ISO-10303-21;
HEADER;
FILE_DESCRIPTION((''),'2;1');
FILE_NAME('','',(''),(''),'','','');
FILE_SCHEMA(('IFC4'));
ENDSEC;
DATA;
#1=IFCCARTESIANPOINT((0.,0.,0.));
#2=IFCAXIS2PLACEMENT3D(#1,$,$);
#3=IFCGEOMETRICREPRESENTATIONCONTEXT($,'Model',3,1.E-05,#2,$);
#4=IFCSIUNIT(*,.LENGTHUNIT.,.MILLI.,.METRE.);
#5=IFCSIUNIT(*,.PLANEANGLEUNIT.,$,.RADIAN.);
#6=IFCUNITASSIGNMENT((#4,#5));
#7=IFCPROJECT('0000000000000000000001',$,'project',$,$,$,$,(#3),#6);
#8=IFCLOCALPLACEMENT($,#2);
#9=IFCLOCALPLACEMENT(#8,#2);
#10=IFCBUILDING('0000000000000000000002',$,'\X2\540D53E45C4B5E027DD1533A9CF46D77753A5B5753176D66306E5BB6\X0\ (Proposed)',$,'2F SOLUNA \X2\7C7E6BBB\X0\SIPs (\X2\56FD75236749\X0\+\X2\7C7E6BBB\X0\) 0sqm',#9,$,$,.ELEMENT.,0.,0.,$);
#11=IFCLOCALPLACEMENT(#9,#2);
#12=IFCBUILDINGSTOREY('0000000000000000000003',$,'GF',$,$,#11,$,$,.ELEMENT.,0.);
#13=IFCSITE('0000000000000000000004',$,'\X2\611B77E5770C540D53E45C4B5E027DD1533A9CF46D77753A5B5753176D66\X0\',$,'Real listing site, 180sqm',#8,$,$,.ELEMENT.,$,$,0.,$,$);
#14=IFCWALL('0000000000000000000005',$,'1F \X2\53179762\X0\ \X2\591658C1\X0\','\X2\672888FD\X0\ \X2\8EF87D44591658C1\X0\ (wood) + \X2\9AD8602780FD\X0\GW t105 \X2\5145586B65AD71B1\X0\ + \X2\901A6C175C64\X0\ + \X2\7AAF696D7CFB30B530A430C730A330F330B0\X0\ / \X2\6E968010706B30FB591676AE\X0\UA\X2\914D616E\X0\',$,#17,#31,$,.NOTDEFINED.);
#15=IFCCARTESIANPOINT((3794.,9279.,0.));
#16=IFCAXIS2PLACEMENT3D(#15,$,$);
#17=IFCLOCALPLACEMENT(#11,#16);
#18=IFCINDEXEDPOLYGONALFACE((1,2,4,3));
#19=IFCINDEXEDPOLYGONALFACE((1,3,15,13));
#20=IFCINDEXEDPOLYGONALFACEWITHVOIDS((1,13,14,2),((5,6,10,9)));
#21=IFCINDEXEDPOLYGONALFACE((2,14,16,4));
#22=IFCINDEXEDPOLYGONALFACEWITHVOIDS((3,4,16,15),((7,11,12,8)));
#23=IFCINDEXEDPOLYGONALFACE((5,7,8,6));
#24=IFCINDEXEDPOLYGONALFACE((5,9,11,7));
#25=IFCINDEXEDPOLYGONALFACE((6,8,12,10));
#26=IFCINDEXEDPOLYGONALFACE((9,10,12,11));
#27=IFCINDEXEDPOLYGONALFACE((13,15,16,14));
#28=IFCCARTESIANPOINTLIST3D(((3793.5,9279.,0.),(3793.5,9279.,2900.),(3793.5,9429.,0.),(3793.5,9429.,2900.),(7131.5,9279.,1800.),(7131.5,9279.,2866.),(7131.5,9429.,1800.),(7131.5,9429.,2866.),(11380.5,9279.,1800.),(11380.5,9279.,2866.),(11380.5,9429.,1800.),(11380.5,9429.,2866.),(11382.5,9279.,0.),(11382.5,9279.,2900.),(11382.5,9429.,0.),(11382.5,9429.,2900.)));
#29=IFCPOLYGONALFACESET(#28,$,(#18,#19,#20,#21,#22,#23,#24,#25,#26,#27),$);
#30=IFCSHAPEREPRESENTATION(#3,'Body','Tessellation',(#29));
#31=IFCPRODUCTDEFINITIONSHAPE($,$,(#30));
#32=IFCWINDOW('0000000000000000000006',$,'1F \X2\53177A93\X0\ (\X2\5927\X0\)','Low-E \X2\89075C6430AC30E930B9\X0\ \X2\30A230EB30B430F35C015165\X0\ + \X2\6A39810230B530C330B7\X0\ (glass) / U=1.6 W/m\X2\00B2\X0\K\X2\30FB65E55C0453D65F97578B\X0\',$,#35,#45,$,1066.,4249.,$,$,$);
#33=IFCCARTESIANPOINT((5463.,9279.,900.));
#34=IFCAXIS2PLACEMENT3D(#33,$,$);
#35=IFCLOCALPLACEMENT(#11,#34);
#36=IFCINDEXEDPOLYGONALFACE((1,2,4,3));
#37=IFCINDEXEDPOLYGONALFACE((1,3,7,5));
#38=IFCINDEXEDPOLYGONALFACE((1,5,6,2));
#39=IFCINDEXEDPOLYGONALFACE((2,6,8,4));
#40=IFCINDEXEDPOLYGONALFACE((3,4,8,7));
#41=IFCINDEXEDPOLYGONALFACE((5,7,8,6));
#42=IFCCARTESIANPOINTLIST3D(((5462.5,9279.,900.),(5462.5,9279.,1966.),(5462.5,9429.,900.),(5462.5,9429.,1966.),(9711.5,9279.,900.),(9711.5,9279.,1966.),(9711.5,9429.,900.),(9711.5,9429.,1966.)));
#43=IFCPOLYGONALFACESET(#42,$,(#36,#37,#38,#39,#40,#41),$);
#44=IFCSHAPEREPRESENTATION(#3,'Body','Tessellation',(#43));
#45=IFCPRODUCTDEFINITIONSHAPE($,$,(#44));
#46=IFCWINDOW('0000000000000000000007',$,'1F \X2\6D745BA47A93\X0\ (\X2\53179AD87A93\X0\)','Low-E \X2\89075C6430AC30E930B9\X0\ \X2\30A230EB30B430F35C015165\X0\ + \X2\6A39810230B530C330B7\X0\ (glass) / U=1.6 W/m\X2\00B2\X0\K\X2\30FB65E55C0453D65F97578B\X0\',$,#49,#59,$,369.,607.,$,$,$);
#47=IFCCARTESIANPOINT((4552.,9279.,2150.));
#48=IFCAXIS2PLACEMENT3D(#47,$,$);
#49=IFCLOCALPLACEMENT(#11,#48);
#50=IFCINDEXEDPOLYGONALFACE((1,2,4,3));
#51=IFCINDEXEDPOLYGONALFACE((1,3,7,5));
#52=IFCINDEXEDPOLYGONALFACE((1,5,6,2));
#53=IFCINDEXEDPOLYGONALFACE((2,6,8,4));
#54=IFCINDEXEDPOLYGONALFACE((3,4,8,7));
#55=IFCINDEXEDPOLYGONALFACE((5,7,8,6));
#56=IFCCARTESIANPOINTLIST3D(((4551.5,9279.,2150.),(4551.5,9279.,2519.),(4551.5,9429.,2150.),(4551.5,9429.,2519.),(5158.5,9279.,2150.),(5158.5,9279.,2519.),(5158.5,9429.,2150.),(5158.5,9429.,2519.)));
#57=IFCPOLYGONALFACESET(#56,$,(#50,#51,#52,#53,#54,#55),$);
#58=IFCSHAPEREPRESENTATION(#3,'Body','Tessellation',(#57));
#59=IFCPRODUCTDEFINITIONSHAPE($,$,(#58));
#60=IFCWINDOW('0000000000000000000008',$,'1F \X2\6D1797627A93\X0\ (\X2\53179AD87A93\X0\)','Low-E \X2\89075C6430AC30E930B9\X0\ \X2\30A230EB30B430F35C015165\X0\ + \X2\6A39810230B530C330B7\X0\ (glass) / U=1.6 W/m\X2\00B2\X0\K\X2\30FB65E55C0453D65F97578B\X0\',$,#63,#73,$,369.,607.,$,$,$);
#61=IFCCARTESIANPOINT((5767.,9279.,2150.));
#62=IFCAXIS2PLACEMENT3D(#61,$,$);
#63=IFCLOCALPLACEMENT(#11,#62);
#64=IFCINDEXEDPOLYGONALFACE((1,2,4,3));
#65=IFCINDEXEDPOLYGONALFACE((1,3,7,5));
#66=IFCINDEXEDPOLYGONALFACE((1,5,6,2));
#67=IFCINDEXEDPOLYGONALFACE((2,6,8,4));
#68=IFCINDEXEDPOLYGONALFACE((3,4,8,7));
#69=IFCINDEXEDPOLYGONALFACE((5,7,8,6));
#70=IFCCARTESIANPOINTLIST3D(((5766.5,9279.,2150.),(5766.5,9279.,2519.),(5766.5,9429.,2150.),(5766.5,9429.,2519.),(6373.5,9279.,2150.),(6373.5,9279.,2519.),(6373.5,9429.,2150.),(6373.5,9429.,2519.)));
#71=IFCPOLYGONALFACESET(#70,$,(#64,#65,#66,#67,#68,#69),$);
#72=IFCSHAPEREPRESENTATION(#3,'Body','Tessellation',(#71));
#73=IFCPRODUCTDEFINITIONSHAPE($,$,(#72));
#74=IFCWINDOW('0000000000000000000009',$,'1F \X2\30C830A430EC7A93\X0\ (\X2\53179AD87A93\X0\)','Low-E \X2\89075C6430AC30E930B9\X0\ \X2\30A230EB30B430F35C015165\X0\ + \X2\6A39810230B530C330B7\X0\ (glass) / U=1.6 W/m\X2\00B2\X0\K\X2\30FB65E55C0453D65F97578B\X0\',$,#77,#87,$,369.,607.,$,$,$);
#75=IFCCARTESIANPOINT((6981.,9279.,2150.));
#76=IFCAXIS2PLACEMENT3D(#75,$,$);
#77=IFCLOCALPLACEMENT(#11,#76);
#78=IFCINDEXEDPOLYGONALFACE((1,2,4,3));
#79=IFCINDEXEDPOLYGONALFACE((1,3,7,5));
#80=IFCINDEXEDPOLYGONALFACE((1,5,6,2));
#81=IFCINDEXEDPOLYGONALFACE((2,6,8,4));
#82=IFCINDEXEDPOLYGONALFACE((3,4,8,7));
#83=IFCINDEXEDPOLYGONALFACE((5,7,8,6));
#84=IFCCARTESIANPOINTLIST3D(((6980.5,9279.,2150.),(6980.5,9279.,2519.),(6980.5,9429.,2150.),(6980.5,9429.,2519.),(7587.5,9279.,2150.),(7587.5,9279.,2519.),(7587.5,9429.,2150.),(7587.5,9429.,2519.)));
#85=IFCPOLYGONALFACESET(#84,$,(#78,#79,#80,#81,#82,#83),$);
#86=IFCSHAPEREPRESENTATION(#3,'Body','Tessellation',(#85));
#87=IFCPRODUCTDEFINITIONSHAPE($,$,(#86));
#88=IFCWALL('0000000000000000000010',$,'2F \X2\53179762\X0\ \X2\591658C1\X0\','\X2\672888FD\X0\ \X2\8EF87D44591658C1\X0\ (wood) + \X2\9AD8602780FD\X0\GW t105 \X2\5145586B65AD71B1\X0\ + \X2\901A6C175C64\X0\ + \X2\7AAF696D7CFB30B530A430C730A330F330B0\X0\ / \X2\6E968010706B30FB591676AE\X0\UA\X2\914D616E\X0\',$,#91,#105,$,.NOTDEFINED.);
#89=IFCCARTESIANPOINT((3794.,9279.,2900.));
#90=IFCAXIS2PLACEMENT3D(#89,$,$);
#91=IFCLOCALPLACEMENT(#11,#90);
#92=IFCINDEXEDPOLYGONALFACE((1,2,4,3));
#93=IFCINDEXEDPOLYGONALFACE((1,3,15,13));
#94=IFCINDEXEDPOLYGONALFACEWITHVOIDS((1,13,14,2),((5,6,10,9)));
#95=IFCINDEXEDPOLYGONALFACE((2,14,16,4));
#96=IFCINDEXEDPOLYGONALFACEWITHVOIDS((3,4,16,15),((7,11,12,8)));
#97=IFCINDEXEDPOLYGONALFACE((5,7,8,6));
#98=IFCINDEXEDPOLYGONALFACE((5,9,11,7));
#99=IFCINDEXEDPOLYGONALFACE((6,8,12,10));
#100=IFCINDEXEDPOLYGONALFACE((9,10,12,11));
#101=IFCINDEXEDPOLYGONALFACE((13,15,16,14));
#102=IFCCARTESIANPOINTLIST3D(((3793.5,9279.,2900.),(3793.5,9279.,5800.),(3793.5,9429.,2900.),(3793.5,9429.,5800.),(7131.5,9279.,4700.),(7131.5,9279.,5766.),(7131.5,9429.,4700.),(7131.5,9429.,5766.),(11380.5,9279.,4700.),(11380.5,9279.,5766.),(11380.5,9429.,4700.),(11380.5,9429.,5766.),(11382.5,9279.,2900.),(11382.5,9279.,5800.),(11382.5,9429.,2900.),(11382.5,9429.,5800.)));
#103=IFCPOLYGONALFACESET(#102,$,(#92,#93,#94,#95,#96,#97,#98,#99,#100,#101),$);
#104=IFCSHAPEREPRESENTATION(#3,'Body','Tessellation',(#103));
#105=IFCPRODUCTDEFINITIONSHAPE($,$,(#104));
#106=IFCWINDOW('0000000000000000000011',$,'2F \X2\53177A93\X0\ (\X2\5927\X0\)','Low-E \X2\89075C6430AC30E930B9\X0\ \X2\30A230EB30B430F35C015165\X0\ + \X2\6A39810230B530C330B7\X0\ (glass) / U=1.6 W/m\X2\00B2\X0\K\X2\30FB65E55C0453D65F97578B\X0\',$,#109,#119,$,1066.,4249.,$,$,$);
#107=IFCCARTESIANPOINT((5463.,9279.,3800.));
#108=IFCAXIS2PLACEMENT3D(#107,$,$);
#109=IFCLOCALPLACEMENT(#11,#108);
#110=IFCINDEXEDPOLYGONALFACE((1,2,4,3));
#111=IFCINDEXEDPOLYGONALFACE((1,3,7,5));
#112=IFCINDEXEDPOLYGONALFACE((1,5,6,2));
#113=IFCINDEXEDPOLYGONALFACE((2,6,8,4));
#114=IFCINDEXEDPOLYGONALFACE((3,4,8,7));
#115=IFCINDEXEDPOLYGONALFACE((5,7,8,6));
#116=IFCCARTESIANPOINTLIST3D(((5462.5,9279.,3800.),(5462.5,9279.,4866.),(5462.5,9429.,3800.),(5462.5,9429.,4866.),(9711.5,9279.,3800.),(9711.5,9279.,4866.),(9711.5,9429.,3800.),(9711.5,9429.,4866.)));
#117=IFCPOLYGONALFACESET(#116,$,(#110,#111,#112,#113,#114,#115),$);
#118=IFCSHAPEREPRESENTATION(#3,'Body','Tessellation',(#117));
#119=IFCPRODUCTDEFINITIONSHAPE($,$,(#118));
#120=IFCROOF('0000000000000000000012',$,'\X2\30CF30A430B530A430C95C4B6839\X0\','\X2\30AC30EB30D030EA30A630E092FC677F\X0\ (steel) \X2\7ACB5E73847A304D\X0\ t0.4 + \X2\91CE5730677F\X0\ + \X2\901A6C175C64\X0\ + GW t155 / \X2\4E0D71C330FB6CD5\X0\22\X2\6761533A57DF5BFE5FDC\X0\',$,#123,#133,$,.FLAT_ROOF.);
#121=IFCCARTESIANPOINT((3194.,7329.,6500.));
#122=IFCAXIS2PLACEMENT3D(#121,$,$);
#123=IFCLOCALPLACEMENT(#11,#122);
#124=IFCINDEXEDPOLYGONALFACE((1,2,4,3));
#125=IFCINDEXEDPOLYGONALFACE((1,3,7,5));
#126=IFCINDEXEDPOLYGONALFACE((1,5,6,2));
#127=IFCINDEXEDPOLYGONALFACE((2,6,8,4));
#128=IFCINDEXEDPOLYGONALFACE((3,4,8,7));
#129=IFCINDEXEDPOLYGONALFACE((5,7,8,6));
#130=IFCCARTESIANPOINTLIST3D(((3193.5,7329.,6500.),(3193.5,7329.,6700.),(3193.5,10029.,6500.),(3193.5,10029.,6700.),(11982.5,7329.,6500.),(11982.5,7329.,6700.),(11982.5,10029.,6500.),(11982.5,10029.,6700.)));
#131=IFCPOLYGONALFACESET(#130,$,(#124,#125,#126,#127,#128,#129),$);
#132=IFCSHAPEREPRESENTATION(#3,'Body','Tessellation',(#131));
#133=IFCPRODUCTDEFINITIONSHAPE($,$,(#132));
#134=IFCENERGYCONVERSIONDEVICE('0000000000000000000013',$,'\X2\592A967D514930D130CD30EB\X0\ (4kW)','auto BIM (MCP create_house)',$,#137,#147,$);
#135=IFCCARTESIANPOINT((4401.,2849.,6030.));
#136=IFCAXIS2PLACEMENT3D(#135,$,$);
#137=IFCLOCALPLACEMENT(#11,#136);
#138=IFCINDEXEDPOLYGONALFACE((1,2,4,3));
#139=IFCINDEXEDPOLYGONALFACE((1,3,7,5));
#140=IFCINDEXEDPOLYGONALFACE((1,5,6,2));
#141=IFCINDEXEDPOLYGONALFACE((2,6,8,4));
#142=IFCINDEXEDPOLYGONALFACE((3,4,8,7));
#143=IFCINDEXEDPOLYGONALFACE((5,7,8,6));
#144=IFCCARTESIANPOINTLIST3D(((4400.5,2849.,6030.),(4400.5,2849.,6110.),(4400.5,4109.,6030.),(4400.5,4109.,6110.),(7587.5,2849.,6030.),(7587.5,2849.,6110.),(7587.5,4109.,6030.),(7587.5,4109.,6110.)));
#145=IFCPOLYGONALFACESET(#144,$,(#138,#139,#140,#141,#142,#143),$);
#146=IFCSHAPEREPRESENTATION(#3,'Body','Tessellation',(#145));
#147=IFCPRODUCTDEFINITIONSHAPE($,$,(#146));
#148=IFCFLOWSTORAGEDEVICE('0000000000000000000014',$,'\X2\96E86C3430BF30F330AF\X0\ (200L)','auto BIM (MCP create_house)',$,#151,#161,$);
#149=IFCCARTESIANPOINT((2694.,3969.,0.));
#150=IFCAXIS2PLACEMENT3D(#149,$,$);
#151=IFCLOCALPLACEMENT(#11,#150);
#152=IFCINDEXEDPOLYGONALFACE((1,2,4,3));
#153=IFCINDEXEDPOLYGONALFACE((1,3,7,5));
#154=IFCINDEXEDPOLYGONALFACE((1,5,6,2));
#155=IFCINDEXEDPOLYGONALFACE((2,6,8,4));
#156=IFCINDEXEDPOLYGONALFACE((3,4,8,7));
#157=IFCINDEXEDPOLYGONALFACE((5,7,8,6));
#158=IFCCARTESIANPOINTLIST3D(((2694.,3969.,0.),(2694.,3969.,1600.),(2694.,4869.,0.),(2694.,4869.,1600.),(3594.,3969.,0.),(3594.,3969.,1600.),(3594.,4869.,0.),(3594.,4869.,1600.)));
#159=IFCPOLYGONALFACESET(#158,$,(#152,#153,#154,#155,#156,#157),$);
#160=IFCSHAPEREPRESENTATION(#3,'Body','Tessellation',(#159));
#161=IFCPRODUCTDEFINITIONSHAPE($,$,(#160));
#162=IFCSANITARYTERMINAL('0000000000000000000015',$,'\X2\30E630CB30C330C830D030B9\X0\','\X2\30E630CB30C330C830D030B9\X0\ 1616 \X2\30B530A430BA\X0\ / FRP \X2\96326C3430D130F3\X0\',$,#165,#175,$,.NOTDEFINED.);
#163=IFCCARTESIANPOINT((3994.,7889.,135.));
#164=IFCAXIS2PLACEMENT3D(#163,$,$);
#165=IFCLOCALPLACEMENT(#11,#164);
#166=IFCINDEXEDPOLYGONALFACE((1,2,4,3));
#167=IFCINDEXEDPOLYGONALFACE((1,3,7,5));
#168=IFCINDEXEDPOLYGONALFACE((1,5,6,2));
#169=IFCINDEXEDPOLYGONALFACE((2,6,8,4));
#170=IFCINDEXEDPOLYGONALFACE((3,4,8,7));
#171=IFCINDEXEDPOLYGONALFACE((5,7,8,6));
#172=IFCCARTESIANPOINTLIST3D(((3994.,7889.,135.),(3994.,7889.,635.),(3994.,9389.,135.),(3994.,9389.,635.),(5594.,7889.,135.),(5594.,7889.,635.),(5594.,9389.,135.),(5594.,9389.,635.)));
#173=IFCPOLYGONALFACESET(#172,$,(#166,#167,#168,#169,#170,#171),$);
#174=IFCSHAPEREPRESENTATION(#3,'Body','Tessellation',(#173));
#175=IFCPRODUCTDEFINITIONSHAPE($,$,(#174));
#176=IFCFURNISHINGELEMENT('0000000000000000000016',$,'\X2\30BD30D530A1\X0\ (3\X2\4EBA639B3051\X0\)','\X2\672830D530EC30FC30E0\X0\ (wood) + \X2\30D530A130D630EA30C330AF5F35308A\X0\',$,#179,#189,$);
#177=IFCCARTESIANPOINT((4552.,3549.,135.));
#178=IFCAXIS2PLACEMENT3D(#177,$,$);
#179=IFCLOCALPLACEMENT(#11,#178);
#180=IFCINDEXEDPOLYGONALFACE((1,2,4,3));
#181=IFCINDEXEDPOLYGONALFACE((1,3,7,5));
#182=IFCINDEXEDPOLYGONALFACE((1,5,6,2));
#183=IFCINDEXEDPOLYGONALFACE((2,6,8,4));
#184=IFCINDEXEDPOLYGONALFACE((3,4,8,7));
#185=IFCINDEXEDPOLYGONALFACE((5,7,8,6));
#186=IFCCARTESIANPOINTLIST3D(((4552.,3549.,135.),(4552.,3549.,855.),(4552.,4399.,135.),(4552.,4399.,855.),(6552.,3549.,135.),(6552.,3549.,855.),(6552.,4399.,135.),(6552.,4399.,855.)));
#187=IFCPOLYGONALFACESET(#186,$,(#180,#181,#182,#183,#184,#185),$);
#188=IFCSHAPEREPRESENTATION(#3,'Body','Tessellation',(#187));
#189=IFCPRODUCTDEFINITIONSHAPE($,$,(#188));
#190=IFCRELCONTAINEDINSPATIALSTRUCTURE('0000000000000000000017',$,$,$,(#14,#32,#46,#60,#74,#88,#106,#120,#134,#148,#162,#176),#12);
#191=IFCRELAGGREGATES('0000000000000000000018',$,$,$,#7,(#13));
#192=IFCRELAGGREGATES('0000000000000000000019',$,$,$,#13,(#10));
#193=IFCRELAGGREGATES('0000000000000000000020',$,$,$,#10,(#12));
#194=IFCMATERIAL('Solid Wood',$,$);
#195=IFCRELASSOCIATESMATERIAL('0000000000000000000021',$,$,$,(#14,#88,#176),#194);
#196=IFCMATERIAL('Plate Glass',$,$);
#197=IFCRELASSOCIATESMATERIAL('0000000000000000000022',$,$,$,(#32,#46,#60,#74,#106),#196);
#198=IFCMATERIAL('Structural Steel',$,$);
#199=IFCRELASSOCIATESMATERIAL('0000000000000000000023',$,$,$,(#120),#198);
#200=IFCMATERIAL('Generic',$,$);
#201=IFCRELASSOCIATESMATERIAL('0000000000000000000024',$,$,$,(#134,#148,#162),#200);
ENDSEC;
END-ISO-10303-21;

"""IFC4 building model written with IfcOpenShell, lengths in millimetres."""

from ifc_helpers import new_model, si_unit, frame, frame_2d, origin, place, context, project, spatial, rectangle, extrude, material, element, fill, save


model = new_model("IFC4")

# Units and contexts
model_context = context("Model", 3, precision=1e-05, world=origin())
ifc_project = project(units=[si_unit("LENGTHUNIT", "METRE", prefix="MILLI"), si_unit("PLANEANGLEUNIT", "RADIAN")], contexts=[model_context])

# Site, building, storey
site_placement = place(None, origin())
site = spatial("IfcSite", under=ifc_project, at=site_placement, Name="愛知県名古屋市緑区鳴海町字北浦", ObjectType="Real listing site, 180sqm", CompositionType="ELEMENT", RefElevation=0.0)
building_placement = place(site_placement, origin())
building = spatial("IfcBuilding", under=site, at=building_placement, Name="名古屋市緑区鳴海町字北浦の家 (Proposed)", ObjectType="2F SOLUNA 籾殻SIPs (国産杉+籾殻) 0sqm", CompositionType="ELEMENT", ElevationOfRefHeight=0.0, ElevationOfTerrain=0.0)
storey_placement = place(building_placement, origin())
storey = spatial("IfcBuildingStorey", under=building, at=storey_placement, Name="GF", CompositionType="ELEMENT", Elevation=0.0)

# Wall, openings, windows
ifc_material_1 = material(Name="Solid Wood")
wall_1_placement = place(storey_placement, frame((3794.0, 9279.0, 0.0)))
wall_1 = element("IfcWall", 1, at=wall_1_placement, inside=storey, material=ifc_material_1, Name="1F 北面 外壁", Description="木製 軸組外壁 (wood) + 高性能GW t105 充填断熱 + 通気層 + 窯業系サイディング / 準耐火・外皮UA配慮", PredefinedType="NOTDEFINED", context=model_context, shape_type="SweptSolid", body=[
    extrude(rectangle(XDim=7589.0, YDim=150.0, at=frame_2d((3794.0, 75.0))), frame((3794.0, 9279.0, 0.0)), (0.0, 0.0, 1.0), 2900.0),
])
opening_1_placement = place(storey_placement, frame((5463.0, 9279.0, 900.0)))
opening_1 = element("IfcOpeningElement", 2, at=opening_1_placement, cuts=wall_1, PredefinedType="NOTDEFINED", context=model_context, shape_type="SweptSolid", body=[
    extrude(rectangle(XDim=4249.0, YDim=150.0, at=frame_2d((2124.0, 75.0))), frame((5463.0, 9279.0, 900.0)), (0.0, 0.0, 1.0), 1066.0),
])
opening_2_placement = place(storey_placement, frame((4552.0, 9279.0, 2150.0)))
opening_2 = element("IfcOpeningElement", 3, at=opening_2_placement, cuts=wall_1, PredefinedType="NOTDEFINED", context=model_context, shape_type="SweptSolid", body=[
    extrude(rectangle(XDim=607.0, YDim=150.0, at=frame_2d((303.0, 75.0))), frame((4552.0, 9279.0, 2150.0)), (0.0, 0.0, 1.0), 369.0),
])
opening_3_placement = place(storey_placement, frame((5767.0, 9279.0, 2150.0)))
opening_3 = element("IfcOpeningElement", 4, at=opening_3_placement, cuts=wall_1, PredefinedType="NOTDEFINED", context=model_context, shape_type="SweptSolid", body=[
    extrude(rectangle(XDim=607.0, YDim=150.0, at=frame_2d((303.0, 75.0))), frame((5767.0, 9279.0, 2150.0)), (0.0, 0.0, 1.0), 369.0),
])
opening_4_placement = place(storey_placement, frame((6981.0, 9279.0, 2150.0)))
opening_4 = element("IfcOpeningElement", 5, at=opening_4_placement, cuts=wall_1, PredefinedType="NOTDEFINED", context=model_context, shape_type="SweptSolid", body=[
    extrude(rectangle(XDim=607.0, YDim=150.0, at=frame_2d((303.0, 75.0))), frame((6981.0, 9279.0, 2150.0)), (0.0, 0.0, 1.0), 369.0),
])
ifc_material_2 = material(Name="Plate Glass")
window_1_placement = place(storey_placement, frame((5463.0, 9279.0, 900.0)))
window_1 = element("IfcWindow", 6, at=window_1_placement, inside=storey, material=ifc_material_2, Name="1F 北窓 (大)", Description="Low-E 複層ガラス アルゴン封入 + 樹脂サッシ (glass) / U=1.6 W/m²K・日射取得型", OverallHeight=1066.0, OverallWidth=4249.0, context=model_context, shape_type="SweptSolid", body=[
    extrude(rectangle(XDim=4249.0, YDim=150.0, at=frame_2d((2124.0, 75.0))), frame((5463.0, 9279.0, 900.0)), (0.0, 0.0, 1.0), 1066.0),
])
fill(opening_1, window_1)
window_2_placement = place(storey_placement, frame((4552.0, 9279.0, 2150.0)))
window_2 = element("IfcWindow", 7, at=window_2_placement, inside=storey, material=ifc_material_2, Name="1F 浴室窓 (北高窓)", Description="Low-E 複層ガラス アルゴン封入 + 樹脂サッシ (glass) / U=1.6 W/m²K・日射取得型", OverallHeight=369.0, OverallWidth=607.0, context=model_context, shape_type="SweptSolid", body=[
    extrude(rectangle(XDim=607.0, YDim=150.0, at=frame_2d((303.0, 75.0))), frame((4552.0, 9279.0, 2150.0)), (0.0, 0.0, 1.0), 369.0),
])
fill(opening_2, window_2)
window_3_placement = place(storey_placement, frame((5767.0, 9279.0, 2150.0)))
window_3 = element("IfcWindow", 8, at=window_3_placement, inside=storey, material=ifc_material_2, Name="1F 洗面窓 (北高窓)", Description="Low-E 複層ガラス アルゴン封入 + 樹脂サッシ (glass) / U=1.6 W/m²K・日射取得型", OverallHeight=369.0, OverallWidth=607.0, context=model_context, shape_type="SweptSolid", body=[
    extrude(rectangle(XDim=607.0, YDim=150.0, at=frame_2d((303.0, 75.0))), frame((5767.0, 9279.0, 2150.0)), (0.0, 0.0, 1.0), 369.0),
])
fill(opening_3, window_3)
window_4_placement = place(storey_placement, frame((6981.0, 9279.0, 2150.0)))
window_4 = element("IfcWindow", 9, at=window_4_placement, inside=storey, material=ifc_material_2, Name="1F トイレ窓 (北高窓)", Description="Low-E 複層ガラス アルゴン封入 + 樹脂サッシ (glass) / U=1.6 W/m²K・日射取得型", OverallHeight=369.0, OverallWidth=607.0, context=model_context, shape_type="SweptSolid", body=[
    extrude(rectangle(XDim=607.0, YDim=150.0, at=frame_2d((303.0, 75.0))), frame((6981.0, 9279.0, 2150.0)), (0.0, 0.0, 1.0), 369.0),
])
fill(opening_4, window_4)

# Wall, opening, window
wall_2_placement = place(storey_placement, frame((3794.0, 9279.0, 2900.0)))
wall_2 = element("IfcWall", 10, at=wall_2_placement, inside=storey, material=ifc_material_1, Name="2F 北面 外壁", Description="木製 軸組外壁 (wood) + 高性能GW t105 充填断熱 + 通気層 + 窯業系サイディング / 準耐火・外皮UA配慮", PredefinedType="NOTDEFINED", context=model_context, shape_type="SweptSolid", body=[
    extrude(rectangle(XDim=7589.0, YDim=150.0, at=frame_2d((3794.0, 75.0))), frame((3794.0, 9279.0, 2900.0)), (0.0, 0.0, 1.0), 2900.0),
])
opening_5_placement = place(storey_placement, frame((5463.0, 9279.0, 3800.0)))
opening_5 = element("IfcOpeningElement", 11, at=opening_5_placement, cuts=wall_2, PredefinedType="NOTDEFINED", context=model_context, shape_type="SweptSolid", body=[
    extrude(rectangle(XDim=4249.0, YDim=150.0, at=frame_2d((2124.0, 75.0))), frame((5463.0, 9279.0, 3800.0)), (0.0, 0.0, 1.0), 1066.0),
])
window_5_placement = place(storey_placement, frame((5463.0, 9279.0, 3800.0)))
window_5 = element("IfcWindow", 12, at=window_5_placement, inside=storey, material=ifc_material_2, Name="2F 北窓 (大)", Description="Low-E 複層ガラス アルゴン封入 + 樹脂サッシ (glass) / U=1.6 W/m²K・日射取得型", OverallHeight=1066.0, OverallWidth=4249.0, context=model_context, shape_type="SweptSolid", body=[
    extrude(rectangle(XDim=4249.0, YDim=150.0, at=frame_2d((2124.0, 75.0))), frame((5463.0, 9279.0, 3800.0)), (0.0, 0.0, 1.0), 1066.0),
])
fill(opening_5, window_5)

# Roof
ifc_material_3 = material(Name="Structural Steel")
roof_placement = place(storey_placement, frame((3194.0, 7329.0, 6500.0)))
element("IfcRoof", 13, at=roof_placement, inside=storey, material=ifc_material_3, Name="ハイサイド屋根", Description="ガルバリウム鋼板 (steel) 立平葺き t0.4 + 野地板 + 通気層 + GW t155 / 不燃・法22条区域対応", PredefinedType="FLAT_ROOF", context=model_context, shape_type="SweptSolid", body=[
    extrude(rectangle(XDim=8789.0, YDim=2700.0, at=frame_2d((4394.0, 1350.0))), frame((3194.0, 7329.0, 6500.0)), (0.0, 0.0, 1.0), 200.0),
])

# Energy conversion device
ifc_material_4 = material(Name="Generic")
energy_conversion_device_placement = place(storey_placement, frame((4401.0, 2849.0, 6030.0)))
element("IfcEnergyConversionDevice", 14, at=energy_conversion_device_placement, inside=storey, material=ifc_material_4, Name="太陽光パネル (4kW)", Description="auto BIM (MCP create_house)", context=model_context, shape_type="SweptSolid", body=[
    extrude(rectangle(XDim=3187.0, YDim=1260.0, at=frame_2d((1593.0, 630.0))), frame((4401.0, 2849.0, 6030.0)), (0.0, 0.0, 1.0), 80.0),
])

# Flow storage device
flow_storage_device_placement = place(storey_placement, frame((2694.0, 3969.0, 0.0)))
element("IfcFlowStorageDevice", 15, at=flow_storage_device_placement, inside=storey, material=ifc_material_4, Name="雨水タンク (200L)", Description="auto BIM (MCP create_house)", context=model_context, shape_type="SweptSolid", body=[
    extrude(rectangle(XDim=900.0, YDim=900.0, at=frame_2d((450.0, 450.0))), frame((2694.0, 3969.0, 0.0)), (0.0, 0.0, 1.0), 1600.0),
])

# Sanitary terminal
sanitary_terminal_placement = place(storey_placement, frame((3994.0, 7889.0, 135.0)))
element("IfcSanitaryTerminal", 16, at=sanitary_terminal_placement, inside=storey, material=ifc_material_4, Name="ユニットバス", Description="ユニットバス 1616 サイズ / FRP 防水パン", PredefinedType="NOTDEFINED", context=model_context, shape_type="SweptSolid", body=[
    extrude(rectangle(XDim=1600.0, YDim=1500.0, at=frame_2d((800.0, 750.0))), frame((3994.0, 7889.0, 135.0)), (0.0, 0.0, 1.0), 500.0),
])

# Furnishing element
furnishing_1_placement = place(storey_placement, frame((4552.0, 3549.0, 135.0)))
element("IfcFurnishingElement", 17, at=furnishing_1_placement, inside=storey, material=ifc_material_1, Name="ソファ (3人掛け)", Description="木フレーム (wood) + ファブリック張り", context=model_context, shape_type="SweptSolid", body=[
    extrude(rectangle(XDim=2000.0, YDim=850.0, at=frame_2d((1000.0, 425.0))), frame((4552.0, 3549.0, 135.0)), (0.0, 0.0, 1.0), 720.0),
])

save(model, "model.ifc")
